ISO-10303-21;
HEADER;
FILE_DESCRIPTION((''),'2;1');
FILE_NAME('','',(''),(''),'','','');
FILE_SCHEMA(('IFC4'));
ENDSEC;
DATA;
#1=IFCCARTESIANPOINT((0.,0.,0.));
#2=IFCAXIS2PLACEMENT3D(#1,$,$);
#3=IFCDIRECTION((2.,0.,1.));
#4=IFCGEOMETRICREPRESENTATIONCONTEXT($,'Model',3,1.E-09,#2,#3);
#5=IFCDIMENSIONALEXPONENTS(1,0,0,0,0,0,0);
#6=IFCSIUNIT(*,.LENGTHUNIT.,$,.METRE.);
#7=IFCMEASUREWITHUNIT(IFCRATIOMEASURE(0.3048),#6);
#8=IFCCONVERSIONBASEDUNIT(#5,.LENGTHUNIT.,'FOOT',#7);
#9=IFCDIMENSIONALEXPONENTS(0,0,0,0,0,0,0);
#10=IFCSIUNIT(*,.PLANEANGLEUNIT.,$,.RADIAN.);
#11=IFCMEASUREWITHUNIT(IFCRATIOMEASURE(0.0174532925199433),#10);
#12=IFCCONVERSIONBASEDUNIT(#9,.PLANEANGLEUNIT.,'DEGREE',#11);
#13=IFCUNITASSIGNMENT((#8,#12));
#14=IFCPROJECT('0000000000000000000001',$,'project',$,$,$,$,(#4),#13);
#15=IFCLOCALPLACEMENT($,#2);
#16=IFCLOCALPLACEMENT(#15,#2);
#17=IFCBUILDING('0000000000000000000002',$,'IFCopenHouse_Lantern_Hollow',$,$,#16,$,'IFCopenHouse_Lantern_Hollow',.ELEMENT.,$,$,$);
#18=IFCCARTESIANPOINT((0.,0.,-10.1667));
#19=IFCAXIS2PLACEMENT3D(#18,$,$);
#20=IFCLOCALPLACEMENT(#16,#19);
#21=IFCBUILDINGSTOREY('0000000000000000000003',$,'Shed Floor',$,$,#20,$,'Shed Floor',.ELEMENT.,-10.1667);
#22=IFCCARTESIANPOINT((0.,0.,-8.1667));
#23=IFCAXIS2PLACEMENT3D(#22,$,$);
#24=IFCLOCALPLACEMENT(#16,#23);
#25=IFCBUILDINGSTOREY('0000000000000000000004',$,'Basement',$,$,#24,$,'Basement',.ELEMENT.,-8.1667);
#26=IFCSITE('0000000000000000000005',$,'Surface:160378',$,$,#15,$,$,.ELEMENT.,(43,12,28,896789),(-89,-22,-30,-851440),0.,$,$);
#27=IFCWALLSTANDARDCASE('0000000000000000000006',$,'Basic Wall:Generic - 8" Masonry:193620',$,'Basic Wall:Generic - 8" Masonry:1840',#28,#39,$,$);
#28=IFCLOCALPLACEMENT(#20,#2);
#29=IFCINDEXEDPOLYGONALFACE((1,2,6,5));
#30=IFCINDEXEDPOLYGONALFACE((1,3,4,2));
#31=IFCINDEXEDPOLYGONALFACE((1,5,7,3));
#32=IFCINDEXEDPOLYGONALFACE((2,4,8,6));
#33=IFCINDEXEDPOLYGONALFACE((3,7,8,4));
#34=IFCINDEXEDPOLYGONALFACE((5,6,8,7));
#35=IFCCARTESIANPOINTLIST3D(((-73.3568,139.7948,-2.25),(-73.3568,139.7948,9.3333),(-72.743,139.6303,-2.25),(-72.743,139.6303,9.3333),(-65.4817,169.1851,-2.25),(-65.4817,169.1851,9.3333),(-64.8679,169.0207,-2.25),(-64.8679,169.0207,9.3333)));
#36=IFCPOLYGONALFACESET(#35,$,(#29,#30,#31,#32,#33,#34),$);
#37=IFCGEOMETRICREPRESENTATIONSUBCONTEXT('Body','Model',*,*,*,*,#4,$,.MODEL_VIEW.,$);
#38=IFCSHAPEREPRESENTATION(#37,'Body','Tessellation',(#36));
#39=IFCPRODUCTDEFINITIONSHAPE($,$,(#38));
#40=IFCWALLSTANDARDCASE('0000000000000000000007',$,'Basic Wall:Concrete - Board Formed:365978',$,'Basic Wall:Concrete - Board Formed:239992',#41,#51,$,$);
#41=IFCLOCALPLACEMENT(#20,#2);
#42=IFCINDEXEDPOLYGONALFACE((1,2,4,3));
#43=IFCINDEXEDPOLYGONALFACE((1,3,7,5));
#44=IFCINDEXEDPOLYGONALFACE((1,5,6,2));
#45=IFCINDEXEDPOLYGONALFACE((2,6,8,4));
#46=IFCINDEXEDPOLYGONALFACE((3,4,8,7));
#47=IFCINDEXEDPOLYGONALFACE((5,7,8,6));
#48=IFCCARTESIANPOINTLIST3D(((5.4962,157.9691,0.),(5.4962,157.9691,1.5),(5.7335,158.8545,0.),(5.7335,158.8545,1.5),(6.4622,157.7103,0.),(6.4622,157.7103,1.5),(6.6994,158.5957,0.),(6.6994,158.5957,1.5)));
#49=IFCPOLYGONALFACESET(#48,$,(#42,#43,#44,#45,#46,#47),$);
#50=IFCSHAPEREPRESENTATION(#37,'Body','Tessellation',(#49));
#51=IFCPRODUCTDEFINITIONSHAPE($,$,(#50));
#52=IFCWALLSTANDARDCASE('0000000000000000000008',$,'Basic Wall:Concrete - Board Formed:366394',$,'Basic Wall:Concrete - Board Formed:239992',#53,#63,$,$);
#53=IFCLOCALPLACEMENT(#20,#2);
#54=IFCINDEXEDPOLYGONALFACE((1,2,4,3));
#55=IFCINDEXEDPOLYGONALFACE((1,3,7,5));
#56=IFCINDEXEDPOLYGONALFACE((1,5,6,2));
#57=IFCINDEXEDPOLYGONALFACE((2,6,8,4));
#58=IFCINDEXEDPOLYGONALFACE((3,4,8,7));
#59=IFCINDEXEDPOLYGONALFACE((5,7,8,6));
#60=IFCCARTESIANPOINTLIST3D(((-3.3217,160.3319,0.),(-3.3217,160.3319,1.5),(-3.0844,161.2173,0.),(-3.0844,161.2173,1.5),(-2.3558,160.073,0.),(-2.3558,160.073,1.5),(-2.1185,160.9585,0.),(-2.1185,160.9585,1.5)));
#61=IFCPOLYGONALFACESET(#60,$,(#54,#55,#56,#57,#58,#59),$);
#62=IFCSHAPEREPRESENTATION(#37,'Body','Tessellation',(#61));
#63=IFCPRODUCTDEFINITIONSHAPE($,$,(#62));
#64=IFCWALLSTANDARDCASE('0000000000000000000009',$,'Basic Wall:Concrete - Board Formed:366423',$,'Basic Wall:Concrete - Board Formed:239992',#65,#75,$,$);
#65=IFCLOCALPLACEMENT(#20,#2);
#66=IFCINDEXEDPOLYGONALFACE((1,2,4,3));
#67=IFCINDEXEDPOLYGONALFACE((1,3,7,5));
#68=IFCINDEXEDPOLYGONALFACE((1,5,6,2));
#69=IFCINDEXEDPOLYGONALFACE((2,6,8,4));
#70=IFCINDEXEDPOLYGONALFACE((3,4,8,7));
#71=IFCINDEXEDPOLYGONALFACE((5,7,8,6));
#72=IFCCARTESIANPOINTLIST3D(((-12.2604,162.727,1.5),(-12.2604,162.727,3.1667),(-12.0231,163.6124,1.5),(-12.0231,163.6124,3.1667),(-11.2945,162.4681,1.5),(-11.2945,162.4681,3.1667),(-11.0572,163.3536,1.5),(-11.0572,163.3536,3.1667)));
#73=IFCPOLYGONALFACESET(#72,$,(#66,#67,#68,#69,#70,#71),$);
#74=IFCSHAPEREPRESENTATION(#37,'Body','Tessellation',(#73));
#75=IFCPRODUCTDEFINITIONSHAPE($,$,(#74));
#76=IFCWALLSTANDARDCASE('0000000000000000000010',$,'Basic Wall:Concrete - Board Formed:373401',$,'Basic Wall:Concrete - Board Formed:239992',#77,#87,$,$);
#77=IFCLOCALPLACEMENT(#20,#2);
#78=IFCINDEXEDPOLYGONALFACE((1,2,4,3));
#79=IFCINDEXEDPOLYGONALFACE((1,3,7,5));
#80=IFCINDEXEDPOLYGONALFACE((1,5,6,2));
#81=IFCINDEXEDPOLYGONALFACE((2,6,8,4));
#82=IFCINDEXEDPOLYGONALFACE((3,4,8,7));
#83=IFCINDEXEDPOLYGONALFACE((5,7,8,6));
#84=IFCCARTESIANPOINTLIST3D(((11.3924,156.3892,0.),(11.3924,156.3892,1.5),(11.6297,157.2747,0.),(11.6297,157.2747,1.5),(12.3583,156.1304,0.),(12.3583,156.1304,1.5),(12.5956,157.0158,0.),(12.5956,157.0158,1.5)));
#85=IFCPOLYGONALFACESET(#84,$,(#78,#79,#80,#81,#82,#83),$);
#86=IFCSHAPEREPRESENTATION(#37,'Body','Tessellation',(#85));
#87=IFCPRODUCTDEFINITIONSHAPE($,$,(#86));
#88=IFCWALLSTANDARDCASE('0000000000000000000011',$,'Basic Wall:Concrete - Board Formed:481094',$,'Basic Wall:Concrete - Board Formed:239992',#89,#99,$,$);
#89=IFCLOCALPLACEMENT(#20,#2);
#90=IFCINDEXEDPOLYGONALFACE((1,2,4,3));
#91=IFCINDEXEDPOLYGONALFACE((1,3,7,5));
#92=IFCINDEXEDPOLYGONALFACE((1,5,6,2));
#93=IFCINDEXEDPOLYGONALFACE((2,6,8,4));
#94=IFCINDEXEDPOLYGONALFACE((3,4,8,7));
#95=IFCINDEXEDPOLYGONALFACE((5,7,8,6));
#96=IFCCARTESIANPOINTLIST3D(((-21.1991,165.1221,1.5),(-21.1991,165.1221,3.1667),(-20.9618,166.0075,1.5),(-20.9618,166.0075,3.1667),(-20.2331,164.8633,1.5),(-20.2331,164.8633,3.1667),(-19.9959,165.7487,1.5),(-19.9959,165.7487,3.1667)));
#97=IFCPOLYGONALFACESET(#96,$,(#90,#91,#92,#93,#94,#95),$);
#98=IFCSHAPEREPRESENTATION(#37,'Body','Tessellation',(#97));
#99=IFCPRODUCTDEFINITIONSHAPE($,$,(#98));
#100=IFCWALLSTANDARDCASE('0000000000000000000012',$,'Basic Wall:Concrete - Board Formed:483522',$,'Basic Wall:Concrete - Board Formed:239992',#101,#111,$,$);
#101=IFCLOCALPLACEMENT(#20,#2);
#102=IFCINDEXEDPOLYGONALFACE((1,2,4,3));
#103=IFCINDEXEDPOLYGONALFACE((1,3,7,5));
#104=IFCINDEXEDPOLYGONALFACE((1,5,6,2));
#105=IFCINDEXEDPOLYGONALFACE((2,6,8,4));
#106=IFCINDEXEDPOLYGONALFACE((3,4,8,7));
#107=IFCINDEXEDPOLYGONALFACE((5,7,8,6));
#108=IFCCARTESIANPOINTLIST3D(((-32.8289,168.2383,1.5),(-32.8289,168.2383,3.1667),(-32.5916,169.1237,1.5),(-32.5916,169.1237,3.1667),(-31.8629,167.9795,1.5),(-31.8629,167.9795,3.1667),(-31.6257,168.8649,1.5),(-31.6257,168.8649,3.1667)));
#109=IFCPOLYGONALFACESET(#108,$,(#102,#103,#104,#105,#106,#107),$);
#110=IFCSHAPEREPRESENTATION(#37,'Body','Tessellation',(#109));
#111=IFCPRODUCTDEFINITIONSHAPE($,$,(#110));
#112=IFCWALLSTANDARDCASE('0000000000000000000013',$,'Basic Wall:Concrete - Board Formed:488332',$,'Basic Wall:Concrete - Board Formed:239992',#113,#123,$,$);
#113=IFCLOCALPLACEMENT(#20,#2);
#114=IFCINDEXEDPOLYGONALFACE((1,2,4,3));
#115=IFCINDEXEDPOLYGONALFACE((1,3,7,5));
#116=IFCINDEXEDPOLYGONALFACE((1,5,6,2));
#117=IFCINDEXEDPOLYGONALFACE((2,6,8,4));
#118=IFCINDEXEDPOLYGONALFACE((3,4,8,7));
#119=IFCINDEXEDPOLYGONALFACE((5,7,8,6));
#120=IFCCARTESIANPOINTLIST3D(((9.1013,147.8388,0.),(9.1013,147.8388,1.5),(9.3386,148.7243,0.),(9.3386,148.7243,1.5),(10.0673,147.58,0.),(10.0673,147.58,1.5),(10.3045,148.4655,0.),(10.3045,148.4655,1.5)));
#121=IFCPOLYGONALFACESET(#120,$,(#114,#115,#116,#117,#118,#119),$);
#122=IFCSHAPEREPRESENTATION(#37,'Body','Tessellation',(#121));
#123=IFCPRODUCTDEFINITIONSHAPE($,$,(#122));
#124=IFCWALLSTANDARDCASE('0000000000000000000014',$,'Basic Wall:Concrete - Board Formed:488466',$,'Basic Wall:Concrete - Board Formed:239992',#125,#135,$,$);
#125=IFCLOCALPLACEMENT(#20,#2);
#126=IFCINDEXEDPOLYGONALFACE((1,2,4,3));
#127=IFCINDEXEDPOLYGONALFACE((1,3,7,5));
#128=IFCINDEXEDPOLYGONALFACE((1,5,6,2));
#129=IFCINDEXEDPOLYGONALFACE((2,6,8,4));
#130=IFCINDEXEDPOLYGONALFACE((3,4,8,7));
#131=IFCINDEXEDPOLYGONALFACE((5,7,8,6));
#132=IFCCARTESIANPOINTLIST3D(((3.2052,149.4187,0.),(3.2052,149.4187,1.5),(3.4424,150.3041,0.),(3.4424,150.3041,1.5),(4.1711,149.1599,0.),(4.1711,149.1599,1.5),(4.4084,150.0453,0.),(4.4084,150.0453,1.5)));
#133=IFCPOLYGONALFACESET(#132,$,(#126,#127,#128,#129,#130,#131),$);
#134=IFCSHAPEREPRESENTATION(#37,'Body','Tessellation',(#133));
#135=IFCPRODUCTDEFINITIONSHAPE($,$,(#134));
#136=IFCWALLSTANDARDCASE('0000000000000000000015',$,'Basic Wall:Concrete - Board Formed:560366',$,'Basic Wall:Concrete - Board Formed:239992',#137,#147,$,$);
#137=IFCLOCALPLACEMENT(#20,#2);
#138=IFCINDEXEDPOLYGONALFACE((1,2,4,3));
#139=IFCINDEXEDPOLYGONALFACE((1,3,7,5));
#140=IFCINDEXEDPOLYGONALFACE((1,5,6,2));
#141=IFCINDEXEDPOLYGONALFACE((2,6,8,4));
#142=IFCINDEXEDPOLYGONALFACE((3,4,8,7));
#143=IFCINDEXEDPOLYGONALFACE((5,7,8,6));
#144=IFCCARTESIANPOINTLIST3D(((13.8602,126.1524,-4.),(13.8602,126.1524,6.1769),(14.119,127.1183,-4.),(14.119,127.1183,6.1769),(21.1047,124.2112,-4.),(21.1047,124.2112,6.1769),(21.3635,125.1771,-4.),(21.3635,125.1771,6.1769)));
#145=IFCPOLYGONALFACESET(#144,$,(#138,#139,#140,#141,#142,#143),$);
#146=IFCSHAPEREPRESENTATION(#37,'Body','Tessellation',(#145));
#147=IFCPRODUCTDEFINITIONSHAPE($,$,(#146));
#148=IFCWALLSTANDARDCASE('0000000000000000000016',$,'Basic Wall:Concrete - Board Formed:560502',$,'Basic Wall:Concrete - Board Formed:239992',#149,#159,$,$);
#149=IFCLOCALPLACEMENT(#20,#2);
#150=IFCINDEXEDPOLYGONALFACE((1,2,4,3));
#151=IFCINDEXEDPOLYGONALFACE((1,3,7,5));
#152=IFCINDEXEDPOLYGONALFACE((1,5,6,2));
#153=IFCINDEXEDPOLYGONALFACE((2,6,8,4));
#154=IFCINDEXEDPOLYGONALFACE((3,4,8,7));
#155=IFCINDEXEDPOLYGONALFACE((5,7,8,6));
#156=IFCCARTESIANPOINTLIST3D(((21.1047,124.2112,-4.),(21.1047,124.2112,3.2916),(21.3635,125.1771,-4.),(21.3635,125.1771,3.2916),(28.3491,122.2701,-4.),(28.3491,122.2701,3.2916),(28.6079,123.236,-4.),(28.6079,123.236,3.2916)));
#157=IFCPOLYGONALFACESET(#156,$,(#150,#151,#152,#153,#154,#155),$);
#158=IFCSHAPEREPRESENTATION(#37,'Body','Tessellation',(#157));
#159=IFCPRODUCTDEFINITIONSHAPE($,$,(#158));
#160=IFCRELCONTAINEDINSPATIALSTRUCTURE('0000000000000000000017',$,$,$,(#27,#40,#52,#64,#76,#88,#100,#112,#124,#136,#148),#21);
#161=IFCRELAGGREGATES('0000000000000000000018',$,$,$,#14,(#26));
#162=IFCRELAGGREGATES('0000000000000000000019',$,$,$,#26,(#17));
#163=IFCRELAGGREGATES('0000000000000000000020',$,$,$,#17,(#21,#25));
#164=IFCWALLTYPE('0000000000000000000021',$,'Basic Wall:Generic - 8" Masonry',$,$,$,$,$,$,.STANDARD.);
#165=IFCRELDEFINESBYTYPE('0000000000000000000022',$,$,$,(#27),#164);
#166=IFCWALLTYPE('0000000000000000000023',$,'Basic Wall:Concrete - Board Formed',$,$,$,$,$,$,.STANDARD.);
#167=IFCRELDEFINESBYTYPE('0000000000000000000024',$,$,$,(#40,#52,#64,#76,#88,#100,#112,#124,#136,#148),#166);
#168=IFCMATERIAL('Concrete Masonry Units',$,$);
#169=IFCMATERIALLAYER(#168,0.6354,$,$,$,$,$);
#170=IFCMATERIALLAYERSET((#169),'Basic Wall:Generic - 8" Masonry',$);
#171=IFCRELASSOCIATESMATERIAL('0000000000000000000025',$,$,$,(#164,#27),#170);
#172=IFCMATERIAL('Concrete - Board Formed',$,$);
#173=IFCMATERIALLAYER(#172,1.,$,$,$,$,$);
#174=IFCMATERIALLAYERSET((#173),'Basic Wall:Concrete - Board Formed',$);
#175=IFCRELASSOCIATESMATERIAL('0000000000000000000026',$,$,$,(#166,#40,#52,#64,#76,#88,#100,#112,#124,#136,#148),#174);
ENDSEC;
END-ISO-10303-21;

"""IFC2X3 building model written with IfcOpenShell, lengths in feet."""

from ifc_helpers import new_model, entity, si_unit, converted_unit, direction, frame, frame_2d, origin, place, context, subcontext, project, spatial, rectangle, extrude, material, layer, layer_set, layer_usage, type_object, element, save


model = new_model("IFC2X3")

# Units and contexts
model_context = context("Model", 3, precision=1e-09, world=origin(), true_north=direction((2.0, 0.0, 1.0)))
body_context = subcontext(model_context, "Body", "Model", "MODEL_VIEW")
ifc_project = project(units=[converted_unit("LENGTHUNIT", "FOOT", entity("IfcRatioMeasure", 0.3048), si_unit("LENGTHUNIT", "METRE"), dimensions=[1, 0, 0, 0, 0, 0, 0]), converted_unit("PLANEANGLEUNIT", "DEGREE", entity("IfcRatioMeasure", 0.0174532925199433), si_unit("PLANEANGLEUNIT", "RADIAN"), dimensions=[0, 0, 0, 0, 0, 0, 0])], contexts=[model_context])

# Site, building, storey
site_placement = place(None, origin())
site = spatial("IfcSite", under=ifc_project, at=site_placement, Name="Surface:160378", CompositionType="ELEMENT", RefLatitude=(43, 12, 28, 896789), RefLongitude=(-89, -22, -30, -851440), RefElevation=0.0)
building_placement = place(site_placement, origin())
building = spatial("IfcBuilding", under=site, at=building_placement, Name="IFCopenHouse_Lantern_Hollow", LongName="IFCopenHouse_Lantern_Hollow", CompositionType="ELEMENT")
storey_1_placement = place(building_placement, frame((0.0, 0.0, -10.1667)))
storey_1 = spatial("IfcBuildingStorey", under=building, at=storey_1_placement, Name="Shed Floor", LongName="Shed Floor", CompositionType="ELEMENT", Elevation=-10.1667)

# Shared definitions
ifc_material_1 = material(Name="Concrete Masonry Units")

# Shared definitions
storey_2_placement = place(building_placement, frame((0.0, 0.0, -8.1667)))
storey_2 = spatial("IfcBuildingStorey", under=building, at=storey_2_placement, Name="Basement", LongName="Basement", CompositionType="ELEMENT", Elevation=-8.1667)

# Walls
ifc_layer_1 = layer(ifc_material_1, 0.6354)
ifc_layer_set_1 = layer_set([ifc_layer_1], Name="Basic Wall:Generic - 8\" Masonry")
ifc_layer_usage_1 = layer_usage(ifc_layer_set_1, "AXIS2", "NEGATIVE", 0.3177)
wall_type_1 = type_object("IfcWallType", Name="Basic Wall:Generic - 8\" Masonry", PredefinedType="STANDARD", material=ifc_layer_set_1)
wall_1_placement = place(storey_1_placement, frame((-73.0499, 139.7126, -2.25), z_axis=(0.0, 0.0, 1.0), x_axis=(0.258819, 0.965926, 0.0)))
element("IfcWallStandardCase", 1, at=wall_1_placement, inside=storey_1, type_object=wall_type_1, material=ifc_layer_usage_1, Name="Basic Wall:Generic - 8\" Masonry:193620", ObjectType="Basic Wall:Generic - 8\" Masonry:1840", context=body_context, shape_type="SweptSolid", body=[
    extrude(rectangle(XDim=30.4271, YDim=0.6354, at=frame_2d((15.2135, 0.0), x_axis=(-1.0, 0.0))), origin(), (0.0, 0.0, 1.0), 11.5833),
])
ifc_material_2 = material(Name="Concrete - Board Formed")
ifc_layer_2 = layer(ifc_material_2, 1.0)
ifc_layer_set_2 = layer_set([ifc_layer_2], Name="Basic Wall:Concrete - Board Formed")
ifc_layer_usage_2 = layer_usage(ifc_layer_set_2, "AXIS2", "NEGATIVE", 0.5)
wall_type_2 = type_object("IfcWallType", Name="Basic Wall:Concrete - Board Formed", PredefinedType="STANDARD", material=ifc_layer_set_2)
wall_2_placement = place(storey_1_placement, frame((6.2165, 158.7251, 0.0), z_axis=(0.0, 0.0, 1.0), x_axis=(-0.258819, -0.965926, 0.0)))
element("IfcWallStandardCase", 2, at=wall_2_placement, inside=storey_1, type_object=wall_type_2, material=ifc_layer_usage_2, Name="Basic Wall:Concrete - Board Formed:365978", ObjectType="Basic Wall:Concrete - Board Formed:239992", context=body_context, shape_type="SweptSolid", body=[
    extrude(rectangle(XDim=0.9167, YDim=1.0, at=frame_2d((0.4583, 0.0), x_axis=(-1.0, 0.0))), origin(), (0.0, 0.0, 1.0), 1.5),
])
ifc_layer_usage_3 = layer_usage(ifc_layer_set_2, "AXIS2", "NEGATIVE", 0.5)
wall_3_placement = place(storey_1_placement, frame((-2.6015, 161.0879, 0.0), z_axis=(0.0, 0.0, 1.0), x_axis=(-0.258819, -0.965926, 0.0)))
element("IfcWallStandardCase", 3, at=wall_3_placement, inside=storey_1, type_object=wall_type_2, material=ifc_layer_usage_3, Name="Basic Wall:Concrete - Board Formed:366394", ObjectType="Basic Wall:Concrete - Board Formed:239992", context=body_context, shape_type="SweptSolid", body=[
    extrude(rectangle(XDim=0.9167, YDim=1.0, at=frame_2d((0.4583, 0.0), x_axis=(-1.0, 0.0))), origin(), (0.0, 0.0, 1.0), 1.5),
])
ifc_layer_usage_4 = layer_usage(ifc_layer_set_2, "AXIS2", "NEGATIVE", 0.5)
wall_4_placement = place(storey_1_placement, frame((-11.5402, 163.483, 1.5), z_axis=(0.0, 0.0, 1.0), x_axis=(-0.258819, -0.965926, 0.0)))
element("IfcWallStandardCase", 4, at=wall_4_placement, inside=storey_1, type_object=wall_type_2, material=ifc_layer_usage_4, Name="Basic Wall:Concrete - Board Formed:366423", ObjectType="Basic Wall:Concrete - Board Formed:239992", context=body_context, shape_type="SweptSolid", body=[
    extrude(rectangle(XDim=0.9167, YDim=1.0, at=frame_2d((0.4583, 0.0), x_axis=(-1.0, 0.0))), origin(), (0.0, 0.0, 1.0), 1.6667),
])
ifc_layer_usage_5 = layer_usage(ifc_layer_set_2, "AXIS2", "NEGATIVE", 0.5)
wall_5_placement = place(storey_1_placement, frame((12.1126, 157.1452, 0.0), z_axis=(0.0, 0.0, 1.0), x_axis=(-0.258819, -0.965926, 0.0)))
element("IfcWallStandardCase", 5, at=wall_5_placement, inside=storey_1, type_object=wall_type_2, material=ifc_layer_usage_5, Name="Basic Wall:Concrete - Board Formed:373401", ObjectType="Basic Wall:Concrete - Board Formed:239992", context=body_context, shape_type="SweptSolid", body=[
    extrude(rectangle(XDim=0.9167, YDim=1.0, at=frame_2d((0.4583, 0.0), x_axis=(-1.0, 0.0))), origin(), (0.0, 0.0, 1.0), 1.5),
])
ifc_layer_usage_6 = layer_usage(ifc_layer_set_2, "AXIS2", "NEGATIVE", 0.5)
wall_6_placement = place(storey_1_placement, frame((-20.4788, 165.8781, 1.5), z_axis=(0.0, 0.0, 1.0), x_axis=(-0.258819, -0.965926, 0.0)))
element("IfcWallStandardCase", 6, at=wall_6_placement, inside=storey_1, type_object=wall_type_2, material=ifc_layer_usage_6, Name="Basic Wall:Concrete - Board Formed:481094", ObjectType="Basic Wall:Concrete - Board Formed:239992", context=body_context, shape_type="SweptSolid", body=[
    extrude(rectangle(XDim=0.9167, YDim=1.0, at=frame_2d((0.4583, 0.0), x_axis=(-1.0, 0.0))), origin(), (0.0, 0.0, 1.0), 1.6667),
])
ifc_layer_usage_7 = layer_usage(ifc_layer_set_2, "AXIS2", "NEGATIVE", 0.5)
wall_7_placement = place(storey_1_placement, frame((-32.1087, 168.9943, 1.5), z_axis=(0.0, 0.0, 1.0), x_axis=(-0.258819, -0.965926, 0.0)))
element("IfcWallStandardCase", 7, at=wall_7_placement, inside=storey_1, type_object=wall_type_2, material=ifc_layer_usage_7, Name="Basic Wall:Concrete - Board Formed:483522", ObjectType="Basic Wall:Concrete - Board Formed:239992", context=body_context, shape_type="SweptSolid", body=[
    extrude(rectangle(XDim=0.9167, YDim=1.0, at=frame_2d((0.4583, 0.0), x_axis=(-1.0, 0.0))), origin(), (0.0, 0.0, 1.0), 1.6667),
])
ifc_layer_usage_8 = layer_usage(ifc_layer_set_2, "AXIS2", "NEGATIVE", 0.5)
wall_8_placement = place(storey_1_placement, frame((9.8216, 148.5949, 0.0), z_axis=(0.0, 0.0, 1.0), x_axis=(-0.258819, -0.965926, 0.0)))
element("IfcWallStandardCase", 8, at=wall_8_placement, inside=storey_1, type_object=wall_type_2, material=ifc_layer_usage_8, Name="Basic Wall:Concrete - Board Formed:488332", ObjectType="Basic Wall:Concrete - Board Formed:239992", context=body_context, shape_type="SweptSolid", body=[
    extrude(rectangle(XDim=0.9167, YDim=1.0, at=frame_2d((0.4583, 0.0), x_axis=(-1.0, 0.0))), origin(), (0.0, 0.0, 1.0), 1.5),
])
ifc_layer_usage_9 = layer_usage(ifc_layer_set_2, "AXIS2", "NEGATIVE", 0.5)
wall_9_placement = place(storey_1_placement, frame((3.9254, 150.1747, 0.0), z_axis=(0.0, 0.0, 1.0), x_axis=(-0.258819, -0.965926, 0.0)))
element("IfcWallStandardCase", 9, at=wall_9_placement, inside=storey_1, type_object=wall_type_2, material=ifc_layer_usage_9, Name="Basic Wall:Concrete - Board Formed:488466", ObjectType="Basic Wall:Concrete - Board Formed:239992", context=body_context, shape_type="SweptSolid", body=[
    extrude(rectangle(XDim=0.9167, YDim=1.0, at=frame_2d((0.4583, 0.0), x_axis=(-1.0, 0.0))), origin(), (0.0, 0.0, 1.0), 1.5),
])
ifc_layer_usage_10 = layer_usage(ifc_layer_set_2, "AXIS2", "NEGATIVE", 0.5)
wall_10_placement = place(storey_1_placement, frame((13.9896, 126.6353, -4.0), z_axis=(0.0, 0.0, 1.0), x_axis=(0.965926, -0.258819, 0.0)))
element("IfcWallStandardCase", 10, at=wall_10_placement, inside=storey_1, type_object=wall_type_2, material=ifc_layer_usage_10, Name="Basic Wall:Concrete - Board Formed:560366", ObjectType="Basic Wall:Concrete - Board Formed:239992", context=body_context, shape_type="SweptSolid", body=[
    extrude(rectangle(XDim=7.5, YDim=1.0, at=frame_2d((3.75, 0.0), x_axis=(-1.0, 0.0))), origin(), (0.0, 0.0, 1.0), 10.1769),
])
ifc_layer_usage_11 = layer_usage(ifc_layer_set_2, "AXIS2", "NEGATIVE", 0.5)
wall_11_placement = place(storey_1_placement, frame((21.2341, 124.6942, -4.0), z_axis=(0.0, 0.0, 1.0), x_axis=(0.965926, -0.258819, 0.0)))
element("IfcWallStandardCase", 11, at=wall_11_placement, inside=storey_1, type_object=wall_type_2, material=ifc_layer_usage_11, Name="Basic Wall:Concrete - Board Formed:560502", ObjectType="Basic Wall:Concrete - Board Formed:239992", context=body_context, shape_type="SweptSolid", body=[
    extrude(rectangle(XDim=7.5, YDim=1.0, at=frame_2d((3.75, 0.0), x_axis=(-1.0, 0.0))), origin(), (0.0, 0.0, 1.0), 7.2916),
])

save(model, "model.ifc")
